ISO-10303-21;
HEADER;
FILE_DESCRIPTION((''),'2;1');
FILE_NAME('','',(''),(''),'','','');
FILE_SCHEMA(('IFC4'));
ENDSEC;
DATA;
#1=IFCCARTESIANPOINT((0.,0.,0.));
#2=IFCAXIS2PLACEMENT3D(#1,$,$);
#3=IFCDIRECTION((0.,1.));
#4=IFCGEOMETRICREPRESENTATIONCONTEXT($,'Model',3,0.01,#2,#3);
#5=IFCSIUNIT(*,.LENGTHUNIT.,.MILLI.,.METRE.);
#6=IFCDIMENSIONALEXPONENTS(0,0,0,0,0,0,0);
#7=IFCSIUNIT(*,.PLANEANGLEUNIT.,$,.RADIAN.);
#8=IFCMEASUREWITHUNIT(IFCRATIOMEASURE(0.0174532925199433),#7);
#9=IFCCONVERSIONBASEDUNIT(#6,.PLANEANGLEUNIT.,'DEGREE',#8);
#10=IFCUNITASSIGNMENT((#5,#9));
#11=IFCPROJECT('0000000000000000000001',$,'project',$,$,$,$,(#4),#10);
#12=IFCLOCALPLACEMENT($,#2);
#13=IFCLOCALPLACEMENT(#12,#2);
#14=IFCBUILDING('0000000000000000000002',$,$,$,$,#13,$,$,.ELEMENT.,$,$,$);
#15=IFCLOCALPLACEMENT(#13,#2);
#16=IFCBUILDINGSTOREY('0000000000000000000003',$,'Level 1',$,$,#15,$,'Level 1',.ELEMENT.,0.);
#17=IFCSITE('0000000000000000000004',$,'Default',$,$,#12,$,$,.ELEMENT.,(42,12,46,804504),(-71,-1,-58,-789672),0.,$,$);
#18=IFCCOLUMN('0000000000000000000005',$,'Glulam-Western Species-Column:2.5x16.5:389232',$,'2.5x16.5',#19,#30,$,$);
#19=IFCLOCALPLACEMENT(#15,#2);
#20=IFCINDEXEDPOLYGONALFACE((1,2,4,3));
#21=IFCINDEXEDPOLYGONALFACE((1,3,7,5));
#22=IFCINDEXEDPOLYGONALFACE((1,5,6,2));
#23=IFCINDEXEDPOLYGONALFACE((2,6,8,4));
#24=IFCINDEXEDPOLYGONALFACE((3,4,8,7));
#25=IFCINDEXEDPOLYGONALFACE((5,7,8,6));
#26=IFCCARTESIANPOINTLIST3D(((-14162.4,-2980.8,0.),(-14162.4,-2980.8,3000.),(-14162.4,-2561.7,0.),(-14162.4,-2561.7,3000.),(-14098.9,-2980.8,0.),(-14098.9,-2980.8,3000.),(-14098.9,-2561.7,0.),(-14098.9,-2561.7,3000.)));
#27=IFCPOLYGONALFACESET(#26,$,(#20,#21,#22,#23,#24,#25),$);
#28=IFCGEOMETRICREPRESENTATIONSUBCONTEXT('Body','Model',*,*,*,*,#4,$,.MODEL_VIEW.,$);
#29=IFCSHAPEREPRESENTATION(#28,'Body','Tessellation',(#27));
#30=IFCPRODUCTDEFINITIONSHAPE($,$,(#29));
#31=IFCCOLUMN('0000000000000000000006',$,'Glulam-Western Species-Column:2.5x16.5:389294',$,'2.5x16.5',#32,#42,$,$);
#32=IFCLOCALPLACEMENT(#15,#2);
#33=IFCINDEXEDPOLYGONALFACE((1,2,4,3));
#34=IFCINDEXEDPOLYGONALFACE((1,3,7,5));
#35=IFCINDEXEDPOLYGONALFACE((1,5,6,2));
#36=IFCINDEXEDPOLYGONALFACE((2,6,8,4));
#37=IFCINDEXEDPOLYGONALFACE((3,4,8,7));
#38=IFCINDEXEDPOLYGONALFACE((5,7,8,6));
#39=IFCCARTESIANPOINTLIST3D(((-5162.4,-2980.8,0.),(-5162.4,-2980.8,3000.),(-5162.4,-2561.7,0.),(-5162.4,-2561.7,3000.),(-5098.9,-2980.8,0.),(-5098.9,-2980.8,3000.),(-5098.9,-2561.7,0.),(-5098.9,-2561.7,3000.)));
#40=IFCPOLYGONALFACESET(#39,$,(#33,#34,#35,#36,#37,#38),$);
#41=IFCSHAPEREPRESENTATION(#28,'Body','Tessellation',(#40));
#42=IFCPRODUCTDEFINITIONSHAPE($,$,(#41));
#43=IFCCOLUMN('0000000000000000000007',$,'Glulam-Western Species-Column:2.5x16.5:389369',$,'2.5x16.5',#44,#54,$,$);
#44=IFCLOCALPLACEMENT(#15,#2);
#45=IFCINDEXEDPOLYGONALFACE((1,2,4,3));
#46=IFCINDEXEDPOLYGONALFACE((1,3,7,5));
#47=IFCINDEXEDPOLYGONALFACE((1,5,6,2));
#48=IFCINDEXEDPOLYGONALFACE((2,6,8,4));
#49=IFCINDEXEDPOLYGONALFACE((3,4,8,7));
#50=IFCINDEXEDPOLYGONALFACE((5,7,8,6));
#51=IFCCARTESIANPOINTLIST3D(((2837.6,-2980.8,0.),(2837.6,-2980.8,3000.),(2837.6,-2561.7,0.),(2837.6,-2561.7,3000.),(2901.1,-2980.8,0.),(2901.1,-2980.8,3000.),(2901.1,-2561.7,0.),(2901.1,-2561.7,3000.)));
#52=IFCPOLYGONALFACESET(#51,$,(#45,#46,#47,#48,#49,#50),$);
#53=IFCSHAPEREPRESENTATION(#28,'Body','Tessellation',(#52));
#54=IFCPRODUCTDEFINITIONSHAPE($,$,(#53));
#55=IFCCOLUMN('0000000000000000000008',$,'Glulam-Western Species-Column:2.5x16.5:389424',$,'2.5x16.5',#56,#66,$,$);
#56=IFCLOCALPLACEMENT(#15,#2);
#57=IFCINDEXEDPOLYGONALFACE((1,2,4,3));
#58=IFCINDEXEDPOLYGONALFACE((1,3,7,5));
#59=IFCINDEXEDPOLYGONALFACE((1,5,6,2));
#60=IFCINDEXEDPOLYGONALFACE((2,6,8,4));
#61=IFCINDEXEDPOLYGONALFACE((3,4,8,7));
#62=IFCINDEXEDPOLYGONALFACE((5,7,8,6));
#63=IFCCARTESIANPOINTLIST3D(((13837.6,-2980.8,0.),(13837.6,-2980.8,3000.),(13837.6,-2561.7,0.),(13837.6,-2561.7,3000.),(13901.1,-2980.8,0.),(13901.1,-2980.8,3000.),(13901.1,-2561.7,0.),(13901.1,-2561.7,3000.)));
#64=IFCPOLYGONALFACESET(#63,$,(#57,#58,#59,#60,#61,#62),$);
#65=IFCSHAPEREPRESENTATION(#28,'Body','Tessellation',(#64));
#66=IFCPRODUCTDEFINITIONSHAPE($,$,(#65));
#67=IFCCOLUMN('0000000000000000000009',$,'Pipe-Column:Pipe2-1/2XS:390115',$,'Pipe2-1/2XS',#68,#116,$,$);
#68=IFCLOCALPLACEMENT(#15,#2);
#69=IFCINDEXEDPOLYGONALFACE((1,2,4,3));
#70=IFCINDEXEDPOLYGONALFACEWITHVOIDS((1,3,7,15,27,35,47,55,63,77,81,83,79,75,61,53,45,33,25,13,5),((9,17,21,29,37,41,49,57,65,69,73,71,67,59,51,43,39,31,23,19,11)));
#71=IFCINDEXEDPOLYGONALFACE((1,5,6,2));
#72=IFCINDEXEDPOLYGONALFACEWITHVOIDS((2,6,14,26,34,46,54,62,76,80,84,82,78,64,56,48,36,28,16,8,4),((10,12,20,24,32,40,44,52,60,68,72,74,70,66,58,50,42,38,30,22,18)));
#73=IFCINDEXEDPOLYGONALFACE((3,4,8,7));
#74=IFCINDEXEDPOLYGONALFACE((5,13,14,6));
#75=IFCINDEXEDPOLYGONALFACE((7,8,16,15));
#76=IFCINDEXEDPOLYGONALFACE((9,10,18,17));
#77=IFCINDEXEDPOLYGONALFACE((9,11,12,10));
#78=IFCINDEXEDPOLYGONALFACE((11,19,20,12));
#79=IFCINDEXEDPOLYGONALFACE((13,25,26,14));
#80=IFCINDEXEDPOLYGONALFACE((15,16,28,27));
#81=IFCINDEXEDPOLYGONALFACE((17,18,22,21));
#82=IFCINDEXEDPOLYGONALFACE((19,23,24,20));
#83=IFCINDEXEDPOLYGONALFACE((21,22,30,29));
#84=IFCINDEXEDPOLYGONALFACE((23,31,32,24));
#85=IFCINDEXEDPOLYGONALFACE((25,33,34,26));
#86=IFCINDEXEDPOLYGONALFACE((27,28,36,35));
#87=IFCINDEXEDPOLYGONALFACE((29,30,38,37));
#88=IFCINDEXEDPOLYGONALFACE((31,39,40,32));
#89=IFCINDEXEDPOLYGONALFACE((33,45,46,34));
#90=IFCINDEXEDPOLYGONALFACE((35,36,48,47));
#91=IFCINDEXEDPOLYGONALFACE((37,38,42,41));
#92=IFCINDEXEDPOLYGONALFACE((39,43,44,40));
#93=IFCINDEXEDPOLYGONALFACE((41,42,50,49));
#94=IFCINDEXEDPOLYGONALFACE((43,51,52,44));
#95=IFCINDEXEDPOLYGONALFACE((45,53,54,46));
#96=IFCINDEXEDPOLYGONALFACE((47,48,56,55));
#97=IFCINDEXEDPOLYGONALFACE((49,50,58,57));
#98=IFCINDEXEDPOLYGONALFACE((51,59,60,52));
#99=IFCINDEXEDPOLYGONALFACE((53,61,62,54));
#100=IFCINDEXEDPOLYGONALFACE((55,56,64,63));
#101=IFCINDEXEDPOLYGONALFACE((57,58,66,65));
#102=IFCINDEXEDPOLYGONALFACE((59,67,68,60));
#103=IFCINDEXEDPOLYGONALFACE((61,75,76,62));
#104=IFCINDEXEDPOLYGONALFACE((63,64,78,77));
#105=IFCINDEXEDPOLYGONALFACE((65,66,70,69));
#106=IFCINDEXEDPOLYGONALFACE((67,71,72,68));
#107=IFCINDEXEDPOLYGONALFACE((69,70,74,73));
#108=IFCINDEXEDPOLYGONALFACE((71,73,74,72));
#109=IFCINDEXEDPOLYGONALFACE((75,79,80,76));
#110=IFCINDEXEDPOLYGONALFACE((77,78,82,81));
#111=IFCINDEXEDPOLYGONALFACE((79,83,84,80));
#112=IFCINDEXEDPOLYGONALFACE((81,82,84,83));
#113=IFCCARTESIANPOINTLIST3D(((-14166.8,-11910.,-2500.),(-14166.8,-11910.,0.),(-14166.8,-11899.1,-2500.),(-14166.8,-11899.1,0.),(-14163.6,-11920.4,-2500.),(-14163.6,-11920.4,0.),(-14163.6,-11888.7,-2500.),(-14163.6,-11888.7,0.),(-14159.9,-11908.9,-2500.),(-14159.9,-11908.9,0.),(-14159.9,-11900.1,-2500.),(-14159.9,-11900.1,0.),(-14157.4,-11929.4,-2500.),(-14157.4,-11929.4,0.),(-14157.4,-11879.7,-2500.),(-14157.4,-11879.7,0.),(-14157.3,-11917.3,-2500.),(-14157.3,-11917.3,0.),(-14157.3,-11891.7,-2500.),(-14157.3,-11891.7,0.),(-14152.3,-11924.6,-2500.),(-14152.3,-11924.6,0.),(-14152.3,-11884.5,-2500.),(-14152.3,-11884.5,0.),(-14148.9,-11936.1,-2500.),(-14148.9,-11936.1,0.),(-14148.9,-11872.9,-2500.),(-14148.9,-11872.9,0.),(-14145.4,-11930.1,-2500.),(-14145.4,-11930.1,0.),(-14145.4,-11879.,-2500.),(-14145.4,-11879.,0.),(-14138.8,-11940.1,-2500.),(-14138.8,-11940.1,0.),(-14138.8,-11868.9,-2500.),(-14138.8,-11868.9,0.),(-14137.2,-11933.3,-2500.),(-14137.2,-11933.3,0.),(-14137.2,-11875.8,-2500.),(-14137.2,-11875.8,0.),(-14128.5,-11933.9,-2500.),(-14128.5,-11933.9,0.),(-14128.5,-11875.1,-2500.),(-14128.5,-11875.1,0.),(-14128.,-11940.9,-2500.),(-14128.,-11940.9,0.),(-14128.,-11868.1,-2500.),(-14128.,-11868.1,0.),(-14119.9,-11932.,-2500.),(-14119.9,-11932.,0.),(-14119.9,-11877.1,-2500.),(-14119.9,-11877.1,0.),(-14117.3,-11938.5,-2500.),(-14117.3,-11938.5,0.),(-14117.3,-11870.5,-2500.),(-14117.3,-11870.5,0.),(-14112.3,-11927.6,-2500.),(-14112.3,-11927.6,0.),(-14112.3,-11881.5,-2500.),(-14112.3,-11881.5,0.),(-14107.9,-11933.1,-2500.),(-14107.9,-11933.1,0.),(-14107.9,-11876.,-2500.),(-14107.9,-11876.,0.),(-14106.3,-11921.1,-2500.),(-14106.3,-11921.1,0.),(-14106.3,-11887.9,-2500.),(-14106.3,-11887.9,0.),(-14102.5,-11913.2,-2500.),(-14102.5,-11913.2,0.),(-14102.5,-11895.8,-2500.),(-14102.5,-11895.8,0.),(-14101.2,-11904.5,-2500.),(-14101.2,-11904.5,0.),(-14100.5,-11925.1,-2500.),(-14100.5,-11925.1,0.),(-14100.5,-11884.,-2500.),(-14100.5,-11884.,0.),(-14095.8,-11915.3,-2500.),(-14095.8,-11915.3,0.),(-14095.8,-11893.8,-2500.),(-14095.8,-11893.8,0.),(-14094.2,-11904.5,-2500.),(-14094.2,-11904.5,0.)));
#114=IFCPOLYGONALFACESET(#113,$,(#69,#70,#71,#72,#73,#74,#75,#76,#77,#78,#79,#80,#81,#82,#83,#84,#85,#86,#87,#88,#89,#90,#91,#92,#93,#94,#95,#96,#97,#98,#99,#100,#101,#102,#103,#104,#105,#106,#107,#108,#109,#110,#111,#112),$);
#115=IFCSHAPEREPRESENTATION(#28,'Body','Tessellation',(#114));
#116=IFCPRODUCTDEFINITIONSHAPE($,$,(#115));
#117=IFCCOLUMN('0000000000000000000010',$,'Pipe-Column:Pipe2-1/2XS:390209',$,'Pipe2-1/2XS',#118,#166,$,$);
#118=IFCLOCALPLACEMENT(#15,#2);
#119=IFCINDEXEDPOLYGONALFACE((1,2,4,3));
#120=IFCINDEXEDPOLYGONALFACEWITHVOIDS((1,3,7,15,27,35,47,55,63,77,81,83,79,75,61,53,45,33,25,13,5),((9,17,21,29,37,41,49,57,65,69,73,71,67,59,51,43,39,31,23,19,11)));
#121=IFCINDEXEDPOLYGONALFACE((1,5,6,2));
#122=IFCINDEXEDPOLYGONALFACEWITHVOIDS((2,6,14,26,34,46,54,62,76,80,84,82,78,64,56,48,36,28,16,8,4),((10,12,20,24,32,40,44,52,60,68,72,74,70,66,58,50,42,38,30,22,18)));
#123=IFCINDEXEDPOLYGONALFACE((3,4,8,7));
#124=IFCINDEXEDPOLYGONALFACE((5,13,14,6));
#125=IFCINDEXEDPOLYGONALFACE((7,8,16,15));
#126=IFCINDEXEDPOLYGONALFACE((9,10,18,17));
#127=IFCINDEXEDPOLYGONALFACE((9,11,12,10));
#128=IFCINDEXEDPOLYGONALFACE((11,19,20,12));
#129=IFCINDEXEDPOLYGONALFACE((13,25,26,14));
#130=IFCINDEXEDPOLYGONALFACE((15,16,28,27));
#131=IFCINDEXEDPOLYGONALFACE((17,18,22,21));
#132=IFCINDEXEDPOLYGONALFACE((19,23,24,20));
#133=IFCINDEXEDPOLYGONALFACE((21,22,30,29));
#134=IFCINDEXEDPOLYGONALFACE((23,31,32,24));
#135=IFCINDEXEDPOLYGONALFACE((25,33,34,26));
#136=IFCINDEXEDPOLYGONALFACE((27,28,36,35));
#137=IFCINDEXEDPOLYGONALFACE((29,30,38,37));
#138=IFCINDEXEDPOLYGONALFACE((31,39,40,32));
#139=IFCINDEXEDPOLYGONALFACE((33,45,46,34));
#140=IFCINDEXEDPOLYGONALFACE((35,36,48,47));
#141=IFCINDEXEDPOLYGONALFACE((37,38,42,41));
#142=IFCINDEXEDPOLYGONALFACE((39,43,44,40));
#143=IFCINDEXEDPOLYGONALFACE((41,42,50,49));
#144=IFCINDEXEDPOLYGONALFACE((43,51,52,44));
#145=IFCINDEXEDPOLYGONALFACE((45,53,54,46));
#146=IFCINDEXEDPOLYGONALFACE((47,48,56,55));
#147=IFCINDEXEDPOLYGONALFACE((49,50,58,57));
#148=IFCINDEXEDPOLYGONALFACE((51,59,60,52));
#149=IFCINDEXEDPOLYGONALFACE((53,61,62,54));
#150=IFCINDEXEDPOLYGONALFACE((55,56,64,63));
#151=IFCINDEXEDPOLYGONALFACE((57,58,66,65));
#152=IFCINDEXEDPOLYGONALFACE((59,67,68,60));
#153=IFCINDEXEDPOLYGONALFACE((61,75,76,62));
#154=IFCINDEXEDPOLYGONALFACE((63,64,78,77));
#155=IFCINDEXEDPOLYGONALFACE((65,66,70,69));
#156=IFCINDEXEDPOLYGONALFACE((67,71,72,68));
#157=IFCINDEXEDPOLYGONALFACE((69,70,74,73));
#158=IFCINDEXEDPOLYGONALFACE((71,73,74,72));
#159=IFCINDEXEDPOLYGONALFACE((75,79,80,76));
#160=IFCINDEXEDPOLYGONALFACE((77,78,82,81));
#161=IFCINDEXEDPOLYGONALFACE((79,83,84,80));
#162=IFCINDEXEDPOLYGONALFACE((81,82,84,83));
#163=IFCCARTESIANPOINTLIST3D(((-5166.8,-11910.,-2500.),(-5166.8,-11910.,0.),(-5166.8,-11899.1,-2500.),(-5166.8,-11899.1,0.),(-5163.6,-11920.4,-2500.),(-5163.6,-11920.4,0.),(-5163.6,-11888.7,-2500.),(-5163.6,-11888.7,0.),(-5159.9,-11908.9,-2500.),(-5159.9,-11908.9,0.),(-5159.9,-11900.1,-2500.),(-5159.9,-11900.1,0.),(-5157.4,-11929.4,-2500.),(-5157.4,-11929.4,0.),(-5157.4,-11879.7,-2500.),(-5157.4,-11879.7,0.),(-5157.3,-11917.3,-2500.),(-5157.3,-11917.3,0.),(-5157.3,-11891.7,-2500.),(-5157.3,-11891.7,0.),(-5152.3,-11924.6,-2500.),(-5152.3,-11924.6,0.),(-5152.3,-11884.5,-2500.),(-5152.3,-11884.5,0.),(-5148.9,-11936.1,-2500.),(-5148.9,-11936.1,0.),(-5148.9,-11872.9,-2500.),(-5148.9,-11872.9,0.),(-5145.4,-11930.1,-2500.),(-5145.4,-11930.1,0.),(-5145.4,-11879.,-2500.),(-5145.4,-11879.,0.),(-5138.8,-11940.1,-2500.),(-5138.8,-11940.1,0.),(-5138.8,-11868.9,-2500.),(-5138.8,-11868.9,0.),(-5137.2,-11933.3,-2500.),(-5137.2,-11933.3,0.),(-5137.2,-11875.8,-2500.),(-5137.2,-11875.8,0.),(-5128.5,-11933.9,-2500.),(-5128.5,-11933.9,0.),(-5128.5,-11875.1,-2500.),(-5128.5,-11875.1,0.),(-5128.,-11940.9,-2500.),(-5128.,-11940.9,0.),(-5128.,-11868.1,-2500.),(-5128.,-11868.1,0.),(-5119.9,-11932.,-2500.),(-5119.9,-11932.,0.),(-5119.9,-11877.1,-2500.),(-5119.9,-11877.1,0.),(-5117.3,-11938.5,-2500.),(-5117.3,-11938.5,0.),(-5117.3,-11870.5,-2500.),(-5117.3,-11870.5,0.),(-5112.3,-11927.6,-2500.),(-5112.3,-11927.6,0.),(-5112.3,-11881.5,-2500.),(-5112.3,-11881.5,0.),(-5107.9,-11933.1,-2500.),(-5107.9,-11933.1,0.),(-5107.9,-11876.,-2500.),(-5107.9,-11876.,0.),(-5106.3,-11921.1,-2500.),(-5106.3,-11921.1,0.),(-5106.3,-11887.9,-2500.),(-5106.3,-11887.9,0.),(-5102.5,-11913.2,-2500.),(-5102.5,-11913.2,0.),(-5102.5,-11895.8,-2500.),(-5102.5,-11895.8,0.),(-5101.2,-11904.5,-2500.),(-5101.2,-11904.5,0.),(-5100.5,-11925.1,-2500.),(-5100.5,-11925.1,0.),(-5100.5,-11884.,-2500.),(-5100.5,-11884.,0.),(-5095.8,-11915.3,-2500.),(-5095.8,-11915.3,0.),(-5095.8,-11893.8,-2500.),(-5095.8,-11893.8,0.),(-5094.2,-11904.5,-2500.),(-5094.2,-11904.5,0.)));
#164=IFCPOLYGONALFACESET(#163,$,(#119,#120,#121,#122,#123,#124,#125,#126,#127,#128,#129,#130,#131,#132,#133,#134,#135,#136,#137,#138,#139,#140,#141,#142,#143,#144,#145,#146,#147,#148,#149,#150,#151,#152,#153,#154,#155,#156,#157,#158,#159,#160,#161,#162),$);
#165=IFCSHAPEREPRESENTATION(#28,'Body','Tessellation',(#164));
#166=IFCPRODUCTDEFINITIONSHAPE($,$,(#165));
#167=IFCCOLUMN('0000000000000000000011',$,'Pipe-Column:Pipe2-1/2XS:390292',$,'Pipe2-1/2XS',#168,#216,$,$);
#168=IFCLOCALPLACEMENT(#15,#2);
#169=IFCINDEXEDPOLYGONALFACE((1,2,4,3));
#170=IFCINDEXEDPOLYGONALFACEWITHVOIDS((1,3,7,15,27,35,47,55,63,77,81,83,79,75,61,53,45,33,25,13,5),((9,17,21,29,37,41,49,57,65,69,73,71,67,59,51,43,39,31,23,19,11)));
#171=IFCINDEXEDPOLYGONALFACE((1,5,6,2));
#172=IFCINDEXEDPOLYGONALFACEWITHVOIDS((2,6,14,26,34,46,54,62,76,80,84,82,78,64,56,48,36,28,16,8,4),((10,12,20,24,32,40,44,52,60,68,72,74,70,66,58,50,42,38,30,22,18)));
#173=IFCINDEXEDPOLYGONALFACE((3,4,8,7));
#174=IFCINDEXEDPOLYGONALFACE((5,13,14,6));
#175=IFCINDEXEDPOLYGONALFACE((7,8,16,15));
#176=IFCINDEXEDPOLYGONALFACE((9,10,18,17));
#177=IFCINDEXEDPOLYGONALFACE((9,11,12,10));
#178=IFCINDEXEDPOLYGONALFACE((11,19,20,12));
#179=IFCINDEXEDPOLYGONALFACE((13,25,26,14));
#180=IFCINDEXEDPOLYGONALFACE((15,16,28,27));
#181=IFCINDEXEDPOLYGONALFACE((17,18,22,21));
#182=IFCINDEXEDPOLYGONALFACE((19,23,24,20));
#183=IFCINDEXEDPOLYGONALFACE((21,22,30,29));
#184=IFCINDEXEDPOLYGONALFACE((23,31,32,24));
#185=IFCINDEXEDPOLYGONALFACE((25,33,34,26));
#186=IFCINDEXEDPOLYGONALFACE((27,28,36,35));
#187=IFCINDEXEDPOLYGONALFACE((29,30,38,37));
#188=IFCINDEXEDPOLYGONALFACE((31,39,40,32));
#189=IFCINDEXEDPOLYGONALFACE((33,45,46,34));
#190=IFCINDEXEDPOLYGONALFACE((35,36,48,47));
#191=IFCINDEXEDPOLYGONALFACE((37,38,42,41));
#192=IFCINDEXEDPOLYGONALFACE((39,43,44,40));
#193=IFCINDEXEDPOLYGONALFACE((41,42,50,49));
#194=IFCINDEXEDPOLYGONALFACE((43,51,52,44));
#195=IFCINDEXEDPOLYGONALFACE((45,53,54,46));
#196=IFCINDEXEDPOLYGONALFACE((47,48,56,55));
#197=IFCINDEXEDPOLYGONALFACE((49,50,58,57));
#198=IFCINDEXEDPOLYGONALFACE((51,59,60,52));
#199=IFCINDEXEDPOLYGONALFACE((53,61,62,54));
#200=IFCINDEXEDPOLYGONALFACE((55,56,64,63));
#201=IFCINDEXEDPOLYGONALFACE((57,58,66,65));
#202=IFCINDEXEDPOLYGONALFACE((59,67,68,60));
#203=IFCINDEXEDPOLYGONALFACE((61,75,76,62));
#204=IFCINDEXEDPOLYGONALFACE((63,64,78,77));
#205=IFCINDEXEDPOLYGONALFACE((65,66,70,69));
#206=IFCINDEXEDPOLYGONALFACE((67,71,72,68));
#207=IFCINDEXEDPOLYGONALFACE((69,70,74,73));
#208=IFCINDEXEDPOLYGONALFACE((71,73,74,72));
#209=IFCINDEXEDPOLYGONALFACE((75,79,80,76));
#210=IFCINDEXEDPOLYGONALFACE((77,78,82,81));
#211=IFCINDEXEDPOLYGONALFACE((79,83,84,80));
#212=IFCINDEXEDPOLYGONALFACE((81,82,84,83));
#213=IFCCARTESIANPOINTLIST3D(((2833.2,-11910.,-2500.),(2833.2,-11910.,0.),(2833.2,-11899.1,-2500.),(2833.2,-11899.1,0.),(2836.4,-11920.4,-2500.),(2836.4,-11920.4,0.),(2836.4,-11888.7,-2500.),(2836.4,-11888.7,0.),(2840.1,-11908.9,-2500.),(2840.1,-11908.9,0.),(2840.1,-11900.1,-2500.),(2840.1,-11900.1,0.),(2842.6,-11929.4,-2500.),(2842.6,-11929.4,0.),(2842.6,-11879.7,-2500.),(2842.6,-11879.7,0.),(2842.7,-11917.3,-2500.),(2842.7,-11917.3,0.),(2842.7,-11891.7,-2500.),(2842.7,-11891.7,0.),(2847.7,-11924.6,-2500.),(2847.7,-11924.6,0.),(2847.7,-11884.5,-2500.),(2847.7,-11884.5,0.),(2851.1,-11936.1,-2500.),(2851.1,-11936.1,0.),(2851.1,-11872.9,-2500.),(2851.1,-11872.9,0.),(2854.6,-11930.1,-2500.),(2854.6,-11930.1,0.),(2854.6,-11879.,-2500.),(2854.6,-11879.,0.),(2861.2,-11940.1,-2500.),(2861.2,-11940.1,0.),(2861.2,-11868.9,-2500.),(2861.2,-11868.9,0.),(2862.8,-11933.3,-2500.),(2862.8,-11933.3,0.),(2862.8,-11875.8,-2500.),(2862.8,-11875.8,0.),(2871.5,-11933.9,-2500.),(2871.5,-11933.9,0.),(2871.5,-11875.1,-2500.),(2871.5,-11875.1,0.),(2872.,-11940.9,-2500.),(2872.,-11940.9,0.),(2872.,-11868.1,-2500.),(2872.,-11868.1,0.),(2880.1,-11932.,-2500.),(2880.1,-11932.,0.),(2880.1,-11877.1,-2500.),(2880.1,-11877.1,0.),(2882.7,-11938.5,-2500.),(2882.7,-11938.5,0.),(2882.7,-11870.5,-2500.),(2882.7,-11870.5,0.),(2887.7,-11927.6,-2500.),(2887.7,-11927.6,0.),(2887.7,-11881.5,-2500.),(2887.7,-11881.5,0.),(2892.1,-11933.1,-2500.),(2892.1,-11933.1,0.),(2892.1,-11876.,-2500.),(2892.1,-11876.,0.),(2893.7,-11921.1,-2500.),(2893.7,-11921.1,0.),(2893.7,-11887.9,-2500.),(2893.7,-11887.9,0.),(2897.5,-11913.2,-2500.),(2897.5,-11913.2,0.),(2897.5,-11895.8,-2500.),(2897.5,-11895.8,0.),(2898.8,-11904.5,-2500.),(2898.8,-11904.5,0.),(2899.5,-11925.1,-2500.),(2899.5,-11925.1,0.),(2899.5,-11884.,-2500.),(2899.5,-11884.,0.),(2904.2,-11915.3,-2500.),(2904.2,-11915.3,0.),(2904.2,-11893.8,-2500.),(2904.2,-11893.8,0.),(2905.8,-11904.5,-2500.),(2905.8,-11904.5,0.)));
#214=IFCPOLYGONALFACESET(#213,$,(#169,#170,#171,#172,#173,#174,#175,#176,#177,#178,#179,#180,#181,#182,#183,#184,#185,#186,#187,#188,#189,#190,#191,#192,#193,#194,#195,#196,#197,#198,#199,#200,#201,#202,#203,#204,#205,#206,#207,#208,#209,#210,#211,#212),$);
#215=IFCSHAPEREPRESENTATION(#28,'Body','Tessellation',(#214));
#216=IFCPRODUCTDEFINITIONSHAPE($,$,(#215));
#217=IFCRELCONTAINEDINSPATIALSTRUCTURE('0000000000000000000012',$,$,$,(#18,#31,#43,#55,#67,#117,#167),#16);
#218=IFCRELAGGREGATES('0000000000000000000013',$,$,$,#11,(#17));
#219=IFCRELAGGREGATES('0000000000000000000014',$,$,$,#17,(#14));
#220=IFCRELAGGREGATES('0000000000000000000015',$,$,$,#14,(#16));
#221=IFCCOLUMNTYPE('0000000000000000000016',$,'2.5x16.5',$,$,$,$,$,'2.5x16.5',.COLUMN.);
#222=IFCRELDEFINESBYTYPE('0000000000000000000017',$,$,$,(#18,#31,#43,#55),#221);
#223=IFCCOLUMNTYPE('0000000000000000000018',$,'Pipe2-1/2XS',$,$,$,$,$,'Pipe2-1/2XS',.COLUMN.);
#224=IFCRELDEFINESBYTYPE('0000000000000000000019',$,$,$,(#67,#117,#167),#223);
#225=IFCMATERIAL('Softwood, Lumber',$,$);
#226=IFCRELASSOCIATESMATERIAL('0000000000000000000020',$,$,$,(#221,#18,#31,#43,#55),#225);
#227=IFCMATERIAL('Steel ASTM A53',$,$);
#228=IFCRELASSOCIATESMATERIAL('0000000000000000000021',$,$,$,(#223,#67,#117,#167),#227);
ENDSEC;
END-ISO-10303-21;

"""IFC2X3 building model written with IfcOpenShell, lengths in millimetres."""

from ifc_helpers import new_model, entity, si_unit, converted_unit, direction, frame, frame_2d, origin, origin_2d_with_axis, place, context, subcontext, project, spatial, rectangle, hollow_circle, extrude, source, transform, mapped, material, type_object, type_shapes, element, save


model = new_model("IFC2X3")

# Units and contexts
model_context = context("Model", 3, precision=0.01, world=origin(), true_north=direction((0.0, 1.0)))
body_context = subcontext(model_context, "Body", "Model", "MODEL_VIEW")
ifc_project = project(units=[si_unit("LENGTHUNIT", "METRE", prefix="MILLI"), converted_unit("PLANEANGLEUNIT", "DEGREE", entity("IfcRatioMeasure", 0.0174532925199433), si_unit("PLANEANGLEUNIT", "RADIAN"), dimensions=[0, 0, 0, 0, 0, 0, 0])], contexts=[model_context])

# Site, building, storey
site_placement = place(None, origin())
site = spatial("IfcSite", under=ifc_project, at=site_placement, Name="Default", CompositionType="ELEMENT", RefLatitude=(42, 12, 46, 804504), RefLongitude=(-71, -1, -58, -789672), RefElevation=0.0)
building_placement = place(site_placement, origin())
building = spatial("IfcBuilding", under=site, at=building_placement, CompositionType="ELEMENT")
storey_placement = place(building_placement, origin())
storey = spatial("IfcBuildingStorey", under=building, at=storey_placement, Name="Level 1", LongName="Level 1", CompositionType="ELEMENT", Elevation=0.0)

# Columns
ifc_material_1 = material(Name="Softwood, Lumber")
column_type_1 = type_object("IfcColumnType", Name="2.5x16.5", ElementType="2.5x16.5", PredefinedType="COLUMN", material=ifc_material_1)
shared_shape_1 = source(origin(), body_context, "Body", "SweptSolid", [
    extrude(rectangle(XDim=419.1, YDim=63.5, at=origin_2d_with_axis()), frame((0.0, 0.0, 0.0), z_axis=(0.0, 0.0, 1.0), x_axis=(0.0, -1.0, 0.0)), (0.0, 0.0, 1.0), 3000.0),
])
type_shapes(column_type_1, [shared_shape_1])
for number, where, name in (
    (1, (-14130.7, -2771.3, 0.0), "Glulam-Western Species-Column:2.5x16.5:389232"),
    (2, (-5130.7, -2771.3, 0.0), "Glulam-Western Species-Column:2.5x16.5:389294"),
    (3, (2869.3, -2771.3, 0.0), "Glulam-Western Species-Column:2.5x16.5:389369"),
    (4, (13869.3, -2771.3, 0.0), "Glulam-Western Species-Column:2.5x16.5:389424"),
):
    element("IfcColumn", number, at=place(storey_placement, frame(where)), inside=storey, type_object=column_type_1, material=ifc_material_1, Name=name, ObjectType="2.5x16.5", context=body_context, shape_type="MappedRepresentation", body=[
        mapped(shared_shape_1, transform((0.0, 0.0, 0.0), scale=1.0)),
    ])
ifc_material_2 = material(Name="Steel ASTM A53")
column_type_2 = type_object("IfcColumnType", Name="Pipe2-1/2XS", ElementType="Pipe2-1/2XS", PredefinedType="COLUMN", material=ifc_material_2)
shared_shape_2 = source(origin(), body_context, "Body", "SweptSolid", [
    extrude(hollow_circle(Radius=36.5, WallThickness=7.0, at=frame_2d((0.0, 0.0), x_axis=(1.0, 0.0))), frame((0.0, 0.0, -2500.0)), (0.0, 0.0, 1.0), 2500.0),
])
type_shapes(column_type_2, [shared_shape_2])
for number, where, name in (
    (5, (-14130.7, -11904.5, 0.0), "Pipe-Column:Pipe2-1/2XS:390115"),
    (6, (-5130.7, -11904.5, 0.0), "Pipe-Column:Pipe2-1/2XS:390209"),
    (7, (2869.3, -11904.5, 0.0), "Pipe-Column:Pipe2-1/2XS:390292"),
):
    element("IfcColumn", number, at=place(storey_placement, frame(where)), inside=storey, type_object=column_type_2, material=ifc_material_2, Name=name, ObjectType="Pipe2-1/2XS", context=body_context, shape_type="MappedRepresentation", body=[
        mapped(shared_shape_2, transform((0.0, 0.0, 0.0), scale=1.0)),
    ])

save(model, "model.ifc")
